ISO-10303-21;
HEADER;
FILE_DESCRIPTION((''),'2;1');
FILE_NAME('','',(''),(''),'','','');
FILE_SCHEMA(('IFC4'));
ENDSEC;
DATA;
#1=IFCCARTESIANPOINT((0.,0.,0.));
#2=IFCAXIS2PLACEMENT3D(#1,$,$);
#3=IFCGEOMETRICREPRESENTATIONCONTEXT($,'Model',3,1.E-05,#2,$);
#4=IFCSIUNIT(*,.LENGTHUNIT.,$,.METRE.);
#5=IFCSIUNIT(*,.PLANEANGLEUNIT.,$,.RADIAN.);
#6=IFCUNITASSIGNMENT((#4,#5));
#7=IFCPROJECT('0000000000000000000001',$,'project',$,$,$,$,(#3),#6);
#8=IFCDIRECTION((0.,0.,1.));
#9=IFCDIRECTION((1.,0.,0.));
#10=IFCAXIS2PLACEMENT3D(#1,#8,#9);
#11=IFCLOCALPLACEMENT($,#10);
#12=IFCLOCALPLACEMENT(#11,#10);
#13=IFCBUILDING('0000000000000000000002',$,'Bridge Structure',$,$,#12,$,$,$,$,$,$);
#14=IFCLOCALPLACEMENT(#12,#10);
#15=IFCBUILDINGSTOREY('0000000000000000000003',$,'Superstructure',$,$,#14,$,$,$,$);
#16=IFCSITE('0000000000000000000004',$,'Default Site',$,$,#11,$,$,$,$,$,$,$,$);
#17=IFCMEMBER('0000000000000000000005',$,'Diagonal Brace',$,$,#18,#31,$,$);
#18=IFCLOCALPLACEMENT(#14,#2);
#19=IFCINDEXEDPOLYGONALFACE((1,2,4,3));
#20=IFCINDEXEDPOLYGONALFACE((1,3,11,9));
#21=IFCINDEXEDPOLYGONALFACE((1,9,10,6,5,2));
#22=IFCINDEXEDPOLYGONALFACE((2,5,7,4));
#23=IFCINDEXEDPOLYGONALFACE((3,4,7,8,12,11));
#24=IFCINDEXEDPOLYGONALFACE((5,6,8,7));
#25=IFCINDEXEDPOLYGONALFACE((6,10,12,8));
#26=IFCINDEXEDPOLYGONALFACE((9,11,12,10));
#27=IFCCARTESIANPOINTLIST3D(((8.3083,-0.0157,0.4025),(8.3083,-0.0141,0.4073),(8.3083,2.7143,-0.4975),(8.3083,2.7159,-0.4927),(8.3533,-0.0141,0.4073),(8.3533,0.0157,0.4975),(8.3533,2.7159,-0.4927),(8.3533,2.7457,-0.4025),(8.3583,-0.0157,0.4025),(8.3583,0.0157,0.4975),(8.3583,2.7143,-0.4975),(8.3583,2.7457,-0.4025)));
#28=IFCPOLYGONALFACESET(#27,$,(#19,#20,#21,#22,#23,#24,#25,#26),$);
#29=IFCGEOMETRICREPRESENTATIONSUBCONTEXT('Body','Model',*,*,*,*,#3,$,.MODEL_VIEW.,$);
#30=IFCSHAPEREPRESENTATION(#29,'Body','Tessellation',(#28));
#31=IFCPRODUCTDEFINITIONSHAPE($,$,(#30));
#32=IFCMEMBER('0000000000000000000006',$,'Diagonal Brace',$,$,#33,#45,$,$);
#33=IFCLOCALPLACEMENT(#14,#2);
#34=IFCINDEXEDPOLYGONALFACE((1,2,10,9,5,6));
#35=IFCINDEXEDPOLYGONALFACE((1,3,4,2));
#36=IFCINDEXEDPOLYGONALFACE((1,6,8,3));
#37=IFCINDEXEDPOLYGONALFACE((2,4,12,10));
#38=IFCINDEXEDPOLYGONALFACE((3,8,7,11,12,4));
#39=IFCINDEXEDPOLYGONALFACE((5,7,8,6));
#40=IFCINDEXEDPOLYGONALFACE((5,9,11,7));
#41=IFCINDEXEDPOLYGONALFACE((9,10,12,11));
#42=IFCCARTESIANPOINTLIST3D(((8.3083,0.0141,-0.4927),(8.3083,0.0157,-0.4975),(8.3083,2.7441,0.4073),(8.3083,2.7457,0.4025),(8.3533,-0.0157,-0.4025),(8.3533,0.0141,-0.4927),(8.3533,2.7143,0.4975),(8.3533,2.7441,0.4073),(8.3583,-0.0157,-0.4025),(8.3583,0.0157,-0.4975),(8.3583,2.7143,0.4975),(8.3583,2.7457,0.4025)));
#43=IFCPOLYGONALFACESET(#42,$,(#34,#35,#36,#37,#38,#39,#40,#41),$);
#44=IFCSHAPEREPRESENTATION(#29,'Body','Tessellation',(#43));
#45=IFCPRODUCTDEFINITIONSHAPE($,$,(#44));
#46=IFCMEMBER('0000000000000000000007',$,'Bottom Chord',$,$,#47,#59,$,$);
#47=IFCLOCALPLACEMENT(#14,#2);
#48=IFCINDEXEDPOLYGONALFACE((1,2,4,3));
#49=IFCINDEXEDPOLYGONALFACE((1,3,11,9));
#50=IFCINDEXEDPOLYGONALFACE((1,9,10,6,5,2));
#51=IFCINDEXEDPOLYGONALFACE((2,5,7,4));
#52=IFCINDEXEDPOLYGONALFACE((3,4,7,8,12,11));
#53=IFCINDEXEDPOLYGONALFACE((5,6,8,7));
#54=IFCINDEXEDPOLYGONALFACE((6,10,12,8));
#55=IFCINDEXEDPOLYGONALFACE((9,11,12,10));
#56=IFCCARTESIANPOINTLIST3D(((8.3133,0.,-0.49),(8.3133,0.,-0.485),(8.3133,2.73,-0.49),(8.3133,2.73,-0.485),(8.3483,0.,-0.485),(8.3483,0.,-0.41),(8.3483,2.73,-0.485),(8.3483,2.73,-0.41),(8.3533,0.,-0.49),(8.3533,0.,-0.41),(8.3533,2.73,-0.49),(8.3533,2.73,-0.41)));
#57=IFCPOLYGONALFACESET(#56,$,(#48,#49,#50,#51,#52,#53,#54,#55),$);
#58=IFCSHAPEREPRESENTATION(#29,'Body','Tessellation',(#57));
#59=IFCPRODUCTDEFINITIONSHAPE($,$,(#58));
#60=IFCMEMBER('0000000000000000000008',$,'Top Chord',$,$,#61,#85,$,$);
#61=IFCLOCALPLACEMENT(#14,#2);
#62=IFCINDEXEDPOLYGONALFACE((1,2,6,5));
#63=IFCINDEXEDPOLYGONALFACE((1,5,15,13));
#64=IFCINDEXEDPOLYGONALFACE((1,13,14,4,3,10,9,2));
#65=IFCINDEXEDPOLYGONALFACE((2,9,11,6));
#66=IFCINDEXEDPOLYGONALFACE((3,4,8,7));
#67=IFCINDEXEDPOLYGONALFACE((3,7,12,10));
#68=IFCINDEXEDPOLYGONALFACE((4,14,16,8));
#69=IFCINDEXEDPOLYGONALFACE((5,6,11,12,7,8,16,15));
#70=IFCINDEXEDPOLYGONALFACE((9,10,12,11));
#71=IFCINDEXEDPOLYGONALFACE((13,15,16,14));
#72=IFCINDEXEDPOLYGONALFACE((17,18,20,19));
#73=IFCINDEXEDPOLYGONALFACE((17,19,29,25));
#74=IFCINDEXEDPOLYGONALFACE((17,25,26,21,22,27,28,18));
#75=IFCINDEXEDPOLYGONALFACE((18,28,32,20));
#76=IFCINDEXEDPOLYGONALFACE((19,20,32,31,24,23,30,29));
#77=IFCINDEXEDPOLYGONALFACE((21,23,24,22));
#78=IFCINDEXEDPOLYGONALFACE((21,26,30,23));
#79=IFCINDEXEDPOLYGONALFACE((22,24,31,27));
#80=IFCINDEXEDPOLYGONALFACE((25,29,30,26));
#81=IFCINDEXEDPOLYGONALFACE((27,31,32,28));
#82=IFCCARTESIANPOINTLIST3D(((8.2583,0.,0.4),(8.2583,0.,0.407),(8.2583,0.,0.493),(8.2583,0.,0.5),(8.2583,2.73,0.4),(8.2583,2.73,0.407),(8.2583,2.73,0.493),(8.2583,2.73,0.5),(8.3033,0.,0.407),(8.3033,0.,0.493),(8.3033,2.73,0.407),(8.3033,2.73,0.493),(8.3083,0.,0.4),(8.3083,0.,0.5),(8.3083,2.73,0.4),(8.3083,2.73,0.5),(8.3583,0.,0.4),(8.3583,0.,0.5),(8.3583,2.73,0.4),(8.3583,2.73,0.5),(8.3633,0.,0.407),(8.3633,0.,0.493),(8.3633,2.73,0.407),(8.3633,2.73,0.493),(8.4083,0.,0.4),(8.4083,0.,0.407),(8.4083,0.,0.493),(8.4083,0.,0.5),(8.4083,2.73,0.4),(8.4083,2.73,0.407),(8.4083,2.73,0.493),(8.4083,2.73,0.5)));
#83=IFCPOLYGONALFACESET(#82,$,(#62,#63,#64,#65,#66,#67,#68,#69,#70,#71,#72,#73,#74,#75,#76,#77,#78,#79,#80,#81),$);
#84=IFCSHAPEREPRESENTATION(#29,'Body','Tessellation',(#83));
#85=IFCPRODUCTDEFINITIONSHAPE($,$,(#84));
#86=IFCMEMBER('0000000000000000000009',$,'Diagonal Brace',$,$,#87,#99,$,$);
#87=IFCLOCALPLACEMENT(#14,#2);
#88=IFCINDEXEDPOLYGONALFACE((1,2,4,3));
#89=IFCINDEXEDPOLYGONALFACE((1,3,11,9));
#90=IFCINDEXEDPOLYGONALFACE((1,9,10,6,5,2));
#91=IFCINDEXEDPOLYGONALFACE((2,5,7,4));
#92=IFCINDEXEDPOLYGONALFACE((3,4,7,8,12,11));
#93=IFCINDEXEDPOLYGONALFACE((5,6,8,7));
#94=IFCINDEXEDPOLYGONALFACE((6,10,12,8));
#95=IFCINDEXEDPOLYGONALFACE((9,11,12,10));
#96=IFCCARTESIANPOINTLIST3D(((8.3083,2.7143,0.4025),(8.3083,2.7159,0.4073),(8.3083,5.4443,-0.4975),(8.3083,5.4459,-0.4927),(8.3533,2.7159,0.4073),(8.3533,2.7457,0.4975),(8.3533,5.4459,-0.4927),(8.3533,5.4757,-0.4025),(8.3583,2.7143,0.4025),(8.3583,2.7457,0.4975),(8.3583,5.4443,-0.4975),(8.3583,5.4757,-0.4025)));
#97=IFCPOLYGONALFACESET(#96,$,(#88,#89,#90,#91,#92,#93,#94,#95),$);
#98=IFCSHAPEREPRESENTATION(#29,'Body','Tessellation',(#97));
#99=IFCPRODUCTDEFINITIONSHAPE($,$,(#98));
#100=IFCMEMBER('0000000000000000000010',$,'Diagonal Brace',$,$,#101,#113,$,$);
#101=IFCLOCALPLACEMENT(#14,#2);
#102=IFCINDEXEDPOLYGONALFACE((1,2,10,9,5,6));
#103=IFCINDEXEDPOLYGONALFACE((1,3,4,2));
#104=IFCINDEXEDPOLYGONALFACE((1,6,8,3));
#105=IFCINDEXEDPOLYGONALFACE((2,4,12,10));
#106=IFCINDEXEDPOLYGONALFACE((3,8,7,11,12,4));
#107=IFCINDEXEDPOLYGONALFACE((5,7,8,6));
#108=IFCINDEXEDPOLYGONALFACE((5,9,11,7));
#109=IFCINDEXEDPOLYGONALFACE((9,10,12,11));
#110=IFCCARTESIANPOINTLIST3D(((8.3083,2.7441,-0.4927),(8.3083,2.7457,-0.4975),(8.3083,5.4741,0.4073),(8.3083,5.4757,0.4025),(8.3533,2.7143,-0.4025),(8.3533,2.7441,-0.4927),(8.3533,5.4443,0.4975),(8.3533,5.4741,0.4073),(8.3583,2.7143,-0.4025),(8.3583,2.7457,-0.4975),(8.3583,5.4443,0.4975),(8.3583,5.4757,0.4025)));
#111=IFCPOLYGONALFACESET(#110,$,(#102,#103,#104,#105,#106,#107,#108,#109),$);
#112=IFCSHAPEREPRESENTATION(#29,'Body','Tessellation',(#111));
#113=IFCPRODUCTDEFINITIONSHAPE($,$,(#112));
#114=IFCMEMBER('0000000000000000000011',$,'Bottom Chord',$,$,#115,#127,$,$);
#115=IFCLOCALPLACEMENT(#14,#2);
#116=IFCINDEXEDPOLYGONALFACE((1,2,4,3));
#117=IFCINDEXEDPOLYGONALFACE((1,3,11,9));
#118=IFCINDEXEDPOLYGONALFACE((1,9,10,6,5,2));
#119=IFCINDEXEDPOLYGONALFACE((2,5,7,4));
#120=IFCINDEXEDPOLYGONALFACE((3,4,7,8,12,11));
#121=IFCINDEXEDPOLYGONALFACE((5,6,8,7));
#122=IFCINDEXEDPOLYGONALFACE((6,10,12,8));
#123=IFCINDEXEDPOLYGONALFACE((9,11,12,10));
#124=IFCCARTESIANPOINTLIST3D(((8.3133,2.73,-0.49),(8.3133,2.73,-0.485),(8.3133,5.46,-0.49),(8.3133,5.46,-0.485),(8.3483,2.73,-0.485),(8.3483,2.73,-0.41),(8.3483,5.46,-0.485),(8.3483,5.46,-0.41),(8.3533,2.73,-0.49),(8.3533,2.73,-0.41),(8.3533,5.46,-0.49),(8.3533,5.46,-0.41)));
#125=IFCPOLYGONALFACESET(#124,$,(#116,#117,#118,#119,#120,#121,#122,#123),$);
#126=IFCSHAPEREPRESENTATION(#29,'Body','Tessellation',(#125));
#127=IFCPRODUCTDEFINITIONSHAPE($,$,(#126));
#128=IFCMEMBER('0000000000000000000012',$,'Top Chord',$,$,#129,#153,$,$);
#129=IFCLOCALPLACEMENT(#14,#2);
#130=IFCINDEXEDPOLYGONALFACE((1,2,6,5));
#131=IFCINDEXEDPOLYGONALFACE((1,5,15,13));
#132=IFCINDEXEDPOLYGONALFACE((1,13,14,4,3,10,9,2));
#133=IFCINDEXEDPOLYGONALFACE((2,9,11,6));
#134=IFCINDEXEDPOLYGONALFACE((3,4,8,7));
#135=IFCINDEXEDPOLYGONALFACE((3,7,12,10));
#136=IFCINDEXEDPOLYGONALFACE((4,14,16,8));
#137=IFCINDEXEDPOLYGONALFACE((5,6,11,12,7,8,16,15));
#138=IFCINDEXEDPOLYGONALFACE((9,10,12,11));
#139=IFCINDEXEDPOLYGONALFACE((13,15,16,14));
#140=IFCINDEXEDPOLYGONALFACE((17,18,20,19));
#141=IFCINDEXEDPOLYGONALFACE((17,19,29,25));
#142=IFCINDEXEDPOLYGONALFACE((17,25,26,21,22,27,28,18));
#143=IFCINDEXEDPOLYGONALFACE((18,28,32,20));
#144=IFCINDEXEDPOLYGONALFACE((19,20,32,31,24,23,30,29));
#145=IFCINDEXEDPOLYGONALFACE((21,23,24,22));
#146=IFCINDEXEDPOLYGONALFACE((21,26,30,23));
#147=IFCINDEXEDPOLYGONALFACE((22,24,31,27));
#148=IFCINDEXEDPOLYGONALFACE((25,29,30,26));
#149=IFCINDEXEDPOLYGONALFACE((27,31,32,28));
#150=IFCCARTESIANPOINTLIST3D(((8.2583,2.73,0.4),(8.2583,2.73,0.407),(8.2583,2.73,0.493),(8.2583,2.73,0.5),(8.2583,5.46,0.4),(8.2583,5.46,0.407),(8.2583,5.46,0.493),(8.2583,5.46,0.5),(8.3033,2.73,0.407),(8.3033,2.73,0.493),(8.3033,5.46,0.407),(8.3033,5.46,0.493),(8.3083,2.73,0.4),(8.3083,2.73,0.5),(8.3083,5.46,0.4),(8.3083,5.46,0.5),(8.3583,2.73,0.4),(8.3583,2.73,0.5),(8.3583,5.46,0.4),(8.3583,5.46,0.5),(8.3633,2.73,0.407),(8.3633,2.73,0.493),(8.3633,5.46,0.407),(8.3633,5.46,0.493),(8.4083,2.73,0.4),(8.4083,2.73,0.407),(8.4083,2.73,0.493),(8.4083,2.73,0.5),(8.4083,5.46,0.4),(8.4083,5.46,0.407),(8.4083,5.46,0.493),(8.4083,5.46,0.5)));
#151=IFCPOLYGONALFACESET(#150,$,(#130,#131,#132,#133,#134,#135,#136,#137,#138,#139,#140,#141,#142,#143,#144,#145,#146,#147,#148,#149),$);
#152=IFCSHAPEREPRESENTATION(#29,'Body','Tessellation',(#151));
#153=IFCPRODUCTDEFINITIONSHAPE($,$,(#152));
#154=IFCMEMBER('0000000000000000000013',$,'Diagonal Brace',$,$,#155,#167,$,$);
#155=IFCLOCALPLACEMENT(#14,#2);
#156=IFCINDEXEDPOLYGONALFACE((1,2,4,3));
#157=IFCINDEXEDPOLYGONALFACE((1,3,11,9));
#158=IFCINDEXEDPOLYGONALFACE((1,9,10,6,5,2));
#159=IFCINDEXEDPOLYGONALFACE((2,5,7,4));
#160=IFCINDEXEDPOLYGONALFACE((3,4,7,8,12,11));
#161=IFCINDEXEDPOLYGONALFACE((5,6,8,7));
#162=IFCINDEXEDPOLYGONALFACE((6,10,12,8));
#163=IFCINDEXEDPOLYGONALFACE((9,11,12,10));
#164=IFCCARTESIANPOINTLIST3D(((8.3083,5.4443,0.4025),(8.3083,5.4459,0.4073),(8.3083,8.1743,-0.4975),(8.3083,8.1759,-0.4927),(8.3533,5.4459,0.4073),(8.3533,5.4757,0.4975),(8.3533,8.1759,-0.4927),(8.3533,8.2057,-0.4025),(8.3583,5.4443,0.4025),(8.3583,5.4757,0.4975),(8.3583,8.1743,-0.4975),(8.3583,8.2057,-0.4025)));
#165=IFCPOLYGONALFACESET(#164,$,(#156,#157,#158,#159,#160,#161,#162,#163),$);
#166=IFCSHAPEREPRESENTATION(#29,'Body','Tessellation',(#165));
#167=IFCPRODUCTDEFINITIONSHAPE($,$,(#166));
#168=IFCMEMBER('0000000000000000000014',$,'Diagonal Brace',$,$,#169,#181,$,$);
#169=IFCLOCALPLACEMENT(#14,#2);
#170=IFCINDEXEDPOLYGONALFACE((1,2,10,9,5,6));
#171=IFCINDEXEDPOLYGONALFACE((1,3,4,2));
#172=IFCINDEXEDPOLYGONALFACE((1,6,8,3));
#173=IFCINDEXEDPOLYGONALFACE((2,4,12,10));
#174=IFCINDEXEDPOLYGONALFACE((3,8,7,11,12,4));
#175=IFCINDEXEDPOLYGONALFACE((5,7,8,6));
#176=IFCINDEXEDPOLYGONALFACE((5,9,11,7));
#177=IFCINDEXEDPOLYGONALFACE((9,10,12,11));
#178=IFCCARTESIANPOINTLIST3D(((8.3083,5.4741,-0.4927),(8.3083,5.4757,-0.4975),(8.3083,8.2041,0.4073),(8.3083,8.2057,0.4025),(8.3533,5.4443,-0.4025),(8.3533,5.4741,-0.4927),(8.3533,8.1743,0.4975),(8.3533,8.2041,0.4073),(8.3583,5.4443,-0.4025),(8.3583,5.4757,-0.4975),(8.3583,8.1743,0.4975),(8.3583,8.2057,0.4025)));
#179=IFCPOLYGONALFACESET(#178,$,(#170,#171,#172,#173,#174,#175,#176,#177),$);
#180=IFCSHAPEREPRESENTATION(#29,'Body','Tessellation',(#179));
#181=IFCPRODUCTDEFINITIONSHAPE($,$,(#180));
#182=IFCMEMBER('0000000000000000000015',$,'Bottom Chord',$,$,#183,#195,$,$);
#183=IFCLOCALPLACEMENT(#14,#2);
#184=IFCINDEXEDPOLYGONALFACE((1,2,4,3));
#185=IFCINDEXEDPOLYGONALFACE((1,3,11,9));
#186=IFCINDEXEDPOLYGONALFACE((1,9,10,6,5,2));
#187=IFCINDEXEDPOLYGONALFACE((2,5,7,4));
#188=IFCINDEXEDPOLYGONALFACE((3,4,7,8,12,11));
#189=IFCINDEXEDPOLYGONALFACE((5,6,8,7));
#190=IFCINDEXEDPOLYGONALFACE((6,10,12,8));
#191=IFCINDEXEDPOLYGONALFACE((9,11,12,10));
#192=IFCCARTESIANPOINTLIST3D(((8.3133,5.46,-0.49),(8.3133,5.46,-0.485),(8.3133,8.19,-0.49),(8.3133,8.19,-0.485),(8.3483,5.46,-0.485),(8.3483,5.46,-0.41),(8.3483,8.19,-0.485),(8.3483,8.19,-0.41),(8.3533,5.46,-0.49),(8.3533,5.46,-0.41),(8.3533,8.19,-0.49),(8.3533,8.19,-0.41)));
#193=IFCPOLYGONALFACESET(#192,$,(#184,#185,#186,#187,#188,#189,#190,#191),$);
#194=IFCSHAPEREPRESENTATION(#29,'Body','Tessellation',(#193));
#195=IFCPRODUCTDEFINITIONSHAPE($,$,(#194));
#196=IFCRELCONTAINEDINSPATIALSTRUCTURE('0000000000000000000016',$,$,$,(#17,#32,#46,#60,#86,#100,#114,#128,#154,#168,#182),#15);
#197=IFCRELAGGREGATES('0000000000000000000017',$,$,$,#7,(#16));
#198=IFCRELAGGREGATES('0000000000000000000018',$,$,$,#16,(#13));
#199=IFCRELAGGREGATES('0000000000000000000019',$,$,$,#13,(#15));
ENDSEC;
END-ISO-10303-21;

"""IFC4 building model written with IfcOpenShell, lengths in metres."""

from ifc_helpers import new_model, si_unit, frame, origin, origin_with_axes, origin_2d_with_axis, place, context, subcontext, project, spatial, polyline, l_section, outline, composite_profile, extrude, element, save


model = new_model("IFC4")

# Units and contexts
model_context = context("Model", 3, precision=1e-05, world=origin())
body_context = subcontext(model_context, "Body", "Model", "MODEL_VIEW")
ifc_project = project(units=[si_unit("LENGTHUNIT", "METRE"), si_unit("PLANEANGLEUNIT", "RADIAN")], contexts=[model_context])

# Site, building, storey
site_placement = place(None, origin_with_axes())
site = spatial("IfcSite", under=ifc_project, at=site_placement, Name="Default Site")
building_placement = place(site_placement, origin_with_axes())
building = spatial("IfcBuilding", under=site, at=building_placement, Name="Bridge Structure")
storey_placement = place(building_placement, origin_with_axes())
storey = spatial("IfcBuildingStorey", under=building, at=storey_placement, Name="Superstructure")

# Members
for number, where, z_axis, x_axis, name in (
    (1, (8.3333, 0.0, 0.45), (0.0, 0.949722, -0.313095), (-1.0, 0.0, 0.0), "Diagonal Brace"),
    (2, (8.3333, 0.0, -0.45), (0.0, 0.949722, 0.313095), (-1.0, 0.0, 0.0), "Diagonal Brace"),
):
    element("IfcMember", number, at=place(storey_placement, frame(where, z_axis=z_axis, x_axis=x_axis)), inside=storey, Name=name, context=body_context, shape_type="SweptSolid", body=[
        extrude(l_section(Depth=0.1, Width=0.05, Thickness=0.005, at=origin_2d_with_axis()), origin_with_axes(), (0.0, 0.0, 1.0), 2.8745),
    ])
member_1_placement = place(storey_placement, frame((8.3333, 0.0, -0.45), z_axis=(0.0, 1.0, 0.0), x_axis=(-1.0, 0.0, 0.0)))
element("IfcMember", 3, at=member_1_placement, inside=storey, Name="Bottom Chord", context=body_context, shape_type="SweptSolid", body=[
    extrude(l_section(Depth=0.08, Width=0.04, Thickness=0.005, at=origin_2d_with_axis()), origin_with_axes(), (0.0, 0.0, 1.0), 2.73),
])
member_2_placement = place(storey_placement, frame((8.3333, 0.0, 0.45), z_axis=(0.0, 1.0, 0.0), x_axis=(-1.0, 0.0, 0.0)))
element("IfcMember", 4, at=member_2_placement, inside=storey, Name="Top Chord", context=body_context, shape_type="SweptSolid", body=[
    extrude(composite_profile([outline(polyline([(-0.025, -0.05), (-0.025, 0.05), (-0.075, 0.05), (-0.075, 0.043), (-0.03, 0.043), (-0.03, -0.043), (-0.075, -0.043), (-0.075, -0.05), (-0.025, -0.05)])), outline(polyline([(0.025, -0.05), (0.075, -0.05), (0.075, -0.043), (0.03, -0.043), (0.03, 0.043), (0.075, 0.043), (0.075, 0.05), (0.025, 0.05), (0.025, -0.05)]))]), origin_with_axes(), (0.0, 0.0, 1.0), 2.73),
])
for number, where, z_axis, x_axis, name in (
    (5, (8.3333, 2.73, 0.45), (0.0, 0.949722, -0.313095), (-1.0, 0.0, 0.0), "Diagonal Brace"),
    (6, (8.3333, 2.73, -0.45), (0.0, 0.949722, 0.313095), (-1.0, 0.0, 0.0), "Diagonal Brace"),
):
    element("IfcMember", number, at=place(storey_placement, frame(where, z_axis=z_axis, x_axis=x_axis)), inside=storey, Name=name, context=body_context, shape_type="SweptSolid", body=[
        extrude(l_section(Depth=0.1, Width=0.05, Thickness=0.005, at=origin_2d_with_axis()), origin_with_axes(), (0.0, 0.0, 1.0), 2.8745),
    ])
member_3_placement = place(storey_placement, frame((8.3333, 2.73, -0.45), z_axis=(0.0, 1.0, 0.0), x_axis=(-1.0, 0.0, 0.0)))
element("IfcMember", 7, at=member_3_placement, inside=storey, Name="Bottom Chord", context=body_context, shape_type="SweptSolid", body=[
    extrude(l_section(Depth=0.08, Width=0.04, Thickness=0.005, at=origin_2d_with_axis()), origin_with_axes(), (0.0, 0.0, 1.0), 2.73),
])
member_4_placement = place(storey_placement, frame((8.3333, 2.73, 0.45), z_axis=(0.0, 1.0, 0.0), x_axis=(-1.0, 0.0, 0.0)))
element("IfcMember", 8, at=member_4_placement, inside=storey, Name="Top Chord", context=body_context, shape_type="SweptSolid", body=[
    extrude(composite_profile([outline(polyline([(-0.025, -0.05), (-0.025, 0.05), (-0.075, 0.05), (-0.075, 0.043), (-0.03, 0.043), (-0.03, -0.043), (-0.075, -0.043), (-0.075, -0.05), (-0.025, -0.05)])), outline(polyline([(0.025, -0.05), (0.075, -0.05), (0.075, -0.043), (0.03, -0.043), (0.03, 0.043), (0.075, 0.043), (0.075, 0.05), (0.025, 0.05), (0.025, -0.05)]))]), origin_with_axes(), (0.0, 0.0, 1.0), 2.73),
])
for number, where, z_axis, x_axis, name in (
    (9, (8.3333, 5.46, 0.45), (0.0, 0.949722, -0.313095), (-1.0, 0.0, 0.0), "Diagonal Brace"),
    (10, (8.3333, 5.46, -0.45), (0.0, 0.949722, 0.313095), (-1.0, 0.0, 0.0), "Diagonal Brace"),
):
    element("IfcMember", number, at=place(storey_placement, frame(where, z_axis=z_axis, x_axis=x_axis)), inside=storey, Name=name, context=body_context, shape_type="SweptSolid", body=[
        extrude(l_section(Depth=0.1, Width=0.05, Thickness=0.005, at=origin_2d_with_axis()), origin_with_axes(), (0.0, 0.0, 1.0), 2.8745),
    ])
member_5_placement = place(storey_placement, frame((8.3333, 5.46, -0.45), z_axis=(0.0, 1.0, 0.0), x_axis=(-1.0, 0.0, 0.0)))
element("IfcMember", 11, at=member_5_placement, inside=storey, Name="Bottom Chord", context=body_context, shape_type="SweptSolid", body=[
    extrude(l_section(Depth=0.08, Width=0.04, Thickness=0.005, at=origin_2d_with_axis()), origin_with_axes(), (0.0, 0.0, 1.0), 2.73),
])

save(model, "model.ifc")
